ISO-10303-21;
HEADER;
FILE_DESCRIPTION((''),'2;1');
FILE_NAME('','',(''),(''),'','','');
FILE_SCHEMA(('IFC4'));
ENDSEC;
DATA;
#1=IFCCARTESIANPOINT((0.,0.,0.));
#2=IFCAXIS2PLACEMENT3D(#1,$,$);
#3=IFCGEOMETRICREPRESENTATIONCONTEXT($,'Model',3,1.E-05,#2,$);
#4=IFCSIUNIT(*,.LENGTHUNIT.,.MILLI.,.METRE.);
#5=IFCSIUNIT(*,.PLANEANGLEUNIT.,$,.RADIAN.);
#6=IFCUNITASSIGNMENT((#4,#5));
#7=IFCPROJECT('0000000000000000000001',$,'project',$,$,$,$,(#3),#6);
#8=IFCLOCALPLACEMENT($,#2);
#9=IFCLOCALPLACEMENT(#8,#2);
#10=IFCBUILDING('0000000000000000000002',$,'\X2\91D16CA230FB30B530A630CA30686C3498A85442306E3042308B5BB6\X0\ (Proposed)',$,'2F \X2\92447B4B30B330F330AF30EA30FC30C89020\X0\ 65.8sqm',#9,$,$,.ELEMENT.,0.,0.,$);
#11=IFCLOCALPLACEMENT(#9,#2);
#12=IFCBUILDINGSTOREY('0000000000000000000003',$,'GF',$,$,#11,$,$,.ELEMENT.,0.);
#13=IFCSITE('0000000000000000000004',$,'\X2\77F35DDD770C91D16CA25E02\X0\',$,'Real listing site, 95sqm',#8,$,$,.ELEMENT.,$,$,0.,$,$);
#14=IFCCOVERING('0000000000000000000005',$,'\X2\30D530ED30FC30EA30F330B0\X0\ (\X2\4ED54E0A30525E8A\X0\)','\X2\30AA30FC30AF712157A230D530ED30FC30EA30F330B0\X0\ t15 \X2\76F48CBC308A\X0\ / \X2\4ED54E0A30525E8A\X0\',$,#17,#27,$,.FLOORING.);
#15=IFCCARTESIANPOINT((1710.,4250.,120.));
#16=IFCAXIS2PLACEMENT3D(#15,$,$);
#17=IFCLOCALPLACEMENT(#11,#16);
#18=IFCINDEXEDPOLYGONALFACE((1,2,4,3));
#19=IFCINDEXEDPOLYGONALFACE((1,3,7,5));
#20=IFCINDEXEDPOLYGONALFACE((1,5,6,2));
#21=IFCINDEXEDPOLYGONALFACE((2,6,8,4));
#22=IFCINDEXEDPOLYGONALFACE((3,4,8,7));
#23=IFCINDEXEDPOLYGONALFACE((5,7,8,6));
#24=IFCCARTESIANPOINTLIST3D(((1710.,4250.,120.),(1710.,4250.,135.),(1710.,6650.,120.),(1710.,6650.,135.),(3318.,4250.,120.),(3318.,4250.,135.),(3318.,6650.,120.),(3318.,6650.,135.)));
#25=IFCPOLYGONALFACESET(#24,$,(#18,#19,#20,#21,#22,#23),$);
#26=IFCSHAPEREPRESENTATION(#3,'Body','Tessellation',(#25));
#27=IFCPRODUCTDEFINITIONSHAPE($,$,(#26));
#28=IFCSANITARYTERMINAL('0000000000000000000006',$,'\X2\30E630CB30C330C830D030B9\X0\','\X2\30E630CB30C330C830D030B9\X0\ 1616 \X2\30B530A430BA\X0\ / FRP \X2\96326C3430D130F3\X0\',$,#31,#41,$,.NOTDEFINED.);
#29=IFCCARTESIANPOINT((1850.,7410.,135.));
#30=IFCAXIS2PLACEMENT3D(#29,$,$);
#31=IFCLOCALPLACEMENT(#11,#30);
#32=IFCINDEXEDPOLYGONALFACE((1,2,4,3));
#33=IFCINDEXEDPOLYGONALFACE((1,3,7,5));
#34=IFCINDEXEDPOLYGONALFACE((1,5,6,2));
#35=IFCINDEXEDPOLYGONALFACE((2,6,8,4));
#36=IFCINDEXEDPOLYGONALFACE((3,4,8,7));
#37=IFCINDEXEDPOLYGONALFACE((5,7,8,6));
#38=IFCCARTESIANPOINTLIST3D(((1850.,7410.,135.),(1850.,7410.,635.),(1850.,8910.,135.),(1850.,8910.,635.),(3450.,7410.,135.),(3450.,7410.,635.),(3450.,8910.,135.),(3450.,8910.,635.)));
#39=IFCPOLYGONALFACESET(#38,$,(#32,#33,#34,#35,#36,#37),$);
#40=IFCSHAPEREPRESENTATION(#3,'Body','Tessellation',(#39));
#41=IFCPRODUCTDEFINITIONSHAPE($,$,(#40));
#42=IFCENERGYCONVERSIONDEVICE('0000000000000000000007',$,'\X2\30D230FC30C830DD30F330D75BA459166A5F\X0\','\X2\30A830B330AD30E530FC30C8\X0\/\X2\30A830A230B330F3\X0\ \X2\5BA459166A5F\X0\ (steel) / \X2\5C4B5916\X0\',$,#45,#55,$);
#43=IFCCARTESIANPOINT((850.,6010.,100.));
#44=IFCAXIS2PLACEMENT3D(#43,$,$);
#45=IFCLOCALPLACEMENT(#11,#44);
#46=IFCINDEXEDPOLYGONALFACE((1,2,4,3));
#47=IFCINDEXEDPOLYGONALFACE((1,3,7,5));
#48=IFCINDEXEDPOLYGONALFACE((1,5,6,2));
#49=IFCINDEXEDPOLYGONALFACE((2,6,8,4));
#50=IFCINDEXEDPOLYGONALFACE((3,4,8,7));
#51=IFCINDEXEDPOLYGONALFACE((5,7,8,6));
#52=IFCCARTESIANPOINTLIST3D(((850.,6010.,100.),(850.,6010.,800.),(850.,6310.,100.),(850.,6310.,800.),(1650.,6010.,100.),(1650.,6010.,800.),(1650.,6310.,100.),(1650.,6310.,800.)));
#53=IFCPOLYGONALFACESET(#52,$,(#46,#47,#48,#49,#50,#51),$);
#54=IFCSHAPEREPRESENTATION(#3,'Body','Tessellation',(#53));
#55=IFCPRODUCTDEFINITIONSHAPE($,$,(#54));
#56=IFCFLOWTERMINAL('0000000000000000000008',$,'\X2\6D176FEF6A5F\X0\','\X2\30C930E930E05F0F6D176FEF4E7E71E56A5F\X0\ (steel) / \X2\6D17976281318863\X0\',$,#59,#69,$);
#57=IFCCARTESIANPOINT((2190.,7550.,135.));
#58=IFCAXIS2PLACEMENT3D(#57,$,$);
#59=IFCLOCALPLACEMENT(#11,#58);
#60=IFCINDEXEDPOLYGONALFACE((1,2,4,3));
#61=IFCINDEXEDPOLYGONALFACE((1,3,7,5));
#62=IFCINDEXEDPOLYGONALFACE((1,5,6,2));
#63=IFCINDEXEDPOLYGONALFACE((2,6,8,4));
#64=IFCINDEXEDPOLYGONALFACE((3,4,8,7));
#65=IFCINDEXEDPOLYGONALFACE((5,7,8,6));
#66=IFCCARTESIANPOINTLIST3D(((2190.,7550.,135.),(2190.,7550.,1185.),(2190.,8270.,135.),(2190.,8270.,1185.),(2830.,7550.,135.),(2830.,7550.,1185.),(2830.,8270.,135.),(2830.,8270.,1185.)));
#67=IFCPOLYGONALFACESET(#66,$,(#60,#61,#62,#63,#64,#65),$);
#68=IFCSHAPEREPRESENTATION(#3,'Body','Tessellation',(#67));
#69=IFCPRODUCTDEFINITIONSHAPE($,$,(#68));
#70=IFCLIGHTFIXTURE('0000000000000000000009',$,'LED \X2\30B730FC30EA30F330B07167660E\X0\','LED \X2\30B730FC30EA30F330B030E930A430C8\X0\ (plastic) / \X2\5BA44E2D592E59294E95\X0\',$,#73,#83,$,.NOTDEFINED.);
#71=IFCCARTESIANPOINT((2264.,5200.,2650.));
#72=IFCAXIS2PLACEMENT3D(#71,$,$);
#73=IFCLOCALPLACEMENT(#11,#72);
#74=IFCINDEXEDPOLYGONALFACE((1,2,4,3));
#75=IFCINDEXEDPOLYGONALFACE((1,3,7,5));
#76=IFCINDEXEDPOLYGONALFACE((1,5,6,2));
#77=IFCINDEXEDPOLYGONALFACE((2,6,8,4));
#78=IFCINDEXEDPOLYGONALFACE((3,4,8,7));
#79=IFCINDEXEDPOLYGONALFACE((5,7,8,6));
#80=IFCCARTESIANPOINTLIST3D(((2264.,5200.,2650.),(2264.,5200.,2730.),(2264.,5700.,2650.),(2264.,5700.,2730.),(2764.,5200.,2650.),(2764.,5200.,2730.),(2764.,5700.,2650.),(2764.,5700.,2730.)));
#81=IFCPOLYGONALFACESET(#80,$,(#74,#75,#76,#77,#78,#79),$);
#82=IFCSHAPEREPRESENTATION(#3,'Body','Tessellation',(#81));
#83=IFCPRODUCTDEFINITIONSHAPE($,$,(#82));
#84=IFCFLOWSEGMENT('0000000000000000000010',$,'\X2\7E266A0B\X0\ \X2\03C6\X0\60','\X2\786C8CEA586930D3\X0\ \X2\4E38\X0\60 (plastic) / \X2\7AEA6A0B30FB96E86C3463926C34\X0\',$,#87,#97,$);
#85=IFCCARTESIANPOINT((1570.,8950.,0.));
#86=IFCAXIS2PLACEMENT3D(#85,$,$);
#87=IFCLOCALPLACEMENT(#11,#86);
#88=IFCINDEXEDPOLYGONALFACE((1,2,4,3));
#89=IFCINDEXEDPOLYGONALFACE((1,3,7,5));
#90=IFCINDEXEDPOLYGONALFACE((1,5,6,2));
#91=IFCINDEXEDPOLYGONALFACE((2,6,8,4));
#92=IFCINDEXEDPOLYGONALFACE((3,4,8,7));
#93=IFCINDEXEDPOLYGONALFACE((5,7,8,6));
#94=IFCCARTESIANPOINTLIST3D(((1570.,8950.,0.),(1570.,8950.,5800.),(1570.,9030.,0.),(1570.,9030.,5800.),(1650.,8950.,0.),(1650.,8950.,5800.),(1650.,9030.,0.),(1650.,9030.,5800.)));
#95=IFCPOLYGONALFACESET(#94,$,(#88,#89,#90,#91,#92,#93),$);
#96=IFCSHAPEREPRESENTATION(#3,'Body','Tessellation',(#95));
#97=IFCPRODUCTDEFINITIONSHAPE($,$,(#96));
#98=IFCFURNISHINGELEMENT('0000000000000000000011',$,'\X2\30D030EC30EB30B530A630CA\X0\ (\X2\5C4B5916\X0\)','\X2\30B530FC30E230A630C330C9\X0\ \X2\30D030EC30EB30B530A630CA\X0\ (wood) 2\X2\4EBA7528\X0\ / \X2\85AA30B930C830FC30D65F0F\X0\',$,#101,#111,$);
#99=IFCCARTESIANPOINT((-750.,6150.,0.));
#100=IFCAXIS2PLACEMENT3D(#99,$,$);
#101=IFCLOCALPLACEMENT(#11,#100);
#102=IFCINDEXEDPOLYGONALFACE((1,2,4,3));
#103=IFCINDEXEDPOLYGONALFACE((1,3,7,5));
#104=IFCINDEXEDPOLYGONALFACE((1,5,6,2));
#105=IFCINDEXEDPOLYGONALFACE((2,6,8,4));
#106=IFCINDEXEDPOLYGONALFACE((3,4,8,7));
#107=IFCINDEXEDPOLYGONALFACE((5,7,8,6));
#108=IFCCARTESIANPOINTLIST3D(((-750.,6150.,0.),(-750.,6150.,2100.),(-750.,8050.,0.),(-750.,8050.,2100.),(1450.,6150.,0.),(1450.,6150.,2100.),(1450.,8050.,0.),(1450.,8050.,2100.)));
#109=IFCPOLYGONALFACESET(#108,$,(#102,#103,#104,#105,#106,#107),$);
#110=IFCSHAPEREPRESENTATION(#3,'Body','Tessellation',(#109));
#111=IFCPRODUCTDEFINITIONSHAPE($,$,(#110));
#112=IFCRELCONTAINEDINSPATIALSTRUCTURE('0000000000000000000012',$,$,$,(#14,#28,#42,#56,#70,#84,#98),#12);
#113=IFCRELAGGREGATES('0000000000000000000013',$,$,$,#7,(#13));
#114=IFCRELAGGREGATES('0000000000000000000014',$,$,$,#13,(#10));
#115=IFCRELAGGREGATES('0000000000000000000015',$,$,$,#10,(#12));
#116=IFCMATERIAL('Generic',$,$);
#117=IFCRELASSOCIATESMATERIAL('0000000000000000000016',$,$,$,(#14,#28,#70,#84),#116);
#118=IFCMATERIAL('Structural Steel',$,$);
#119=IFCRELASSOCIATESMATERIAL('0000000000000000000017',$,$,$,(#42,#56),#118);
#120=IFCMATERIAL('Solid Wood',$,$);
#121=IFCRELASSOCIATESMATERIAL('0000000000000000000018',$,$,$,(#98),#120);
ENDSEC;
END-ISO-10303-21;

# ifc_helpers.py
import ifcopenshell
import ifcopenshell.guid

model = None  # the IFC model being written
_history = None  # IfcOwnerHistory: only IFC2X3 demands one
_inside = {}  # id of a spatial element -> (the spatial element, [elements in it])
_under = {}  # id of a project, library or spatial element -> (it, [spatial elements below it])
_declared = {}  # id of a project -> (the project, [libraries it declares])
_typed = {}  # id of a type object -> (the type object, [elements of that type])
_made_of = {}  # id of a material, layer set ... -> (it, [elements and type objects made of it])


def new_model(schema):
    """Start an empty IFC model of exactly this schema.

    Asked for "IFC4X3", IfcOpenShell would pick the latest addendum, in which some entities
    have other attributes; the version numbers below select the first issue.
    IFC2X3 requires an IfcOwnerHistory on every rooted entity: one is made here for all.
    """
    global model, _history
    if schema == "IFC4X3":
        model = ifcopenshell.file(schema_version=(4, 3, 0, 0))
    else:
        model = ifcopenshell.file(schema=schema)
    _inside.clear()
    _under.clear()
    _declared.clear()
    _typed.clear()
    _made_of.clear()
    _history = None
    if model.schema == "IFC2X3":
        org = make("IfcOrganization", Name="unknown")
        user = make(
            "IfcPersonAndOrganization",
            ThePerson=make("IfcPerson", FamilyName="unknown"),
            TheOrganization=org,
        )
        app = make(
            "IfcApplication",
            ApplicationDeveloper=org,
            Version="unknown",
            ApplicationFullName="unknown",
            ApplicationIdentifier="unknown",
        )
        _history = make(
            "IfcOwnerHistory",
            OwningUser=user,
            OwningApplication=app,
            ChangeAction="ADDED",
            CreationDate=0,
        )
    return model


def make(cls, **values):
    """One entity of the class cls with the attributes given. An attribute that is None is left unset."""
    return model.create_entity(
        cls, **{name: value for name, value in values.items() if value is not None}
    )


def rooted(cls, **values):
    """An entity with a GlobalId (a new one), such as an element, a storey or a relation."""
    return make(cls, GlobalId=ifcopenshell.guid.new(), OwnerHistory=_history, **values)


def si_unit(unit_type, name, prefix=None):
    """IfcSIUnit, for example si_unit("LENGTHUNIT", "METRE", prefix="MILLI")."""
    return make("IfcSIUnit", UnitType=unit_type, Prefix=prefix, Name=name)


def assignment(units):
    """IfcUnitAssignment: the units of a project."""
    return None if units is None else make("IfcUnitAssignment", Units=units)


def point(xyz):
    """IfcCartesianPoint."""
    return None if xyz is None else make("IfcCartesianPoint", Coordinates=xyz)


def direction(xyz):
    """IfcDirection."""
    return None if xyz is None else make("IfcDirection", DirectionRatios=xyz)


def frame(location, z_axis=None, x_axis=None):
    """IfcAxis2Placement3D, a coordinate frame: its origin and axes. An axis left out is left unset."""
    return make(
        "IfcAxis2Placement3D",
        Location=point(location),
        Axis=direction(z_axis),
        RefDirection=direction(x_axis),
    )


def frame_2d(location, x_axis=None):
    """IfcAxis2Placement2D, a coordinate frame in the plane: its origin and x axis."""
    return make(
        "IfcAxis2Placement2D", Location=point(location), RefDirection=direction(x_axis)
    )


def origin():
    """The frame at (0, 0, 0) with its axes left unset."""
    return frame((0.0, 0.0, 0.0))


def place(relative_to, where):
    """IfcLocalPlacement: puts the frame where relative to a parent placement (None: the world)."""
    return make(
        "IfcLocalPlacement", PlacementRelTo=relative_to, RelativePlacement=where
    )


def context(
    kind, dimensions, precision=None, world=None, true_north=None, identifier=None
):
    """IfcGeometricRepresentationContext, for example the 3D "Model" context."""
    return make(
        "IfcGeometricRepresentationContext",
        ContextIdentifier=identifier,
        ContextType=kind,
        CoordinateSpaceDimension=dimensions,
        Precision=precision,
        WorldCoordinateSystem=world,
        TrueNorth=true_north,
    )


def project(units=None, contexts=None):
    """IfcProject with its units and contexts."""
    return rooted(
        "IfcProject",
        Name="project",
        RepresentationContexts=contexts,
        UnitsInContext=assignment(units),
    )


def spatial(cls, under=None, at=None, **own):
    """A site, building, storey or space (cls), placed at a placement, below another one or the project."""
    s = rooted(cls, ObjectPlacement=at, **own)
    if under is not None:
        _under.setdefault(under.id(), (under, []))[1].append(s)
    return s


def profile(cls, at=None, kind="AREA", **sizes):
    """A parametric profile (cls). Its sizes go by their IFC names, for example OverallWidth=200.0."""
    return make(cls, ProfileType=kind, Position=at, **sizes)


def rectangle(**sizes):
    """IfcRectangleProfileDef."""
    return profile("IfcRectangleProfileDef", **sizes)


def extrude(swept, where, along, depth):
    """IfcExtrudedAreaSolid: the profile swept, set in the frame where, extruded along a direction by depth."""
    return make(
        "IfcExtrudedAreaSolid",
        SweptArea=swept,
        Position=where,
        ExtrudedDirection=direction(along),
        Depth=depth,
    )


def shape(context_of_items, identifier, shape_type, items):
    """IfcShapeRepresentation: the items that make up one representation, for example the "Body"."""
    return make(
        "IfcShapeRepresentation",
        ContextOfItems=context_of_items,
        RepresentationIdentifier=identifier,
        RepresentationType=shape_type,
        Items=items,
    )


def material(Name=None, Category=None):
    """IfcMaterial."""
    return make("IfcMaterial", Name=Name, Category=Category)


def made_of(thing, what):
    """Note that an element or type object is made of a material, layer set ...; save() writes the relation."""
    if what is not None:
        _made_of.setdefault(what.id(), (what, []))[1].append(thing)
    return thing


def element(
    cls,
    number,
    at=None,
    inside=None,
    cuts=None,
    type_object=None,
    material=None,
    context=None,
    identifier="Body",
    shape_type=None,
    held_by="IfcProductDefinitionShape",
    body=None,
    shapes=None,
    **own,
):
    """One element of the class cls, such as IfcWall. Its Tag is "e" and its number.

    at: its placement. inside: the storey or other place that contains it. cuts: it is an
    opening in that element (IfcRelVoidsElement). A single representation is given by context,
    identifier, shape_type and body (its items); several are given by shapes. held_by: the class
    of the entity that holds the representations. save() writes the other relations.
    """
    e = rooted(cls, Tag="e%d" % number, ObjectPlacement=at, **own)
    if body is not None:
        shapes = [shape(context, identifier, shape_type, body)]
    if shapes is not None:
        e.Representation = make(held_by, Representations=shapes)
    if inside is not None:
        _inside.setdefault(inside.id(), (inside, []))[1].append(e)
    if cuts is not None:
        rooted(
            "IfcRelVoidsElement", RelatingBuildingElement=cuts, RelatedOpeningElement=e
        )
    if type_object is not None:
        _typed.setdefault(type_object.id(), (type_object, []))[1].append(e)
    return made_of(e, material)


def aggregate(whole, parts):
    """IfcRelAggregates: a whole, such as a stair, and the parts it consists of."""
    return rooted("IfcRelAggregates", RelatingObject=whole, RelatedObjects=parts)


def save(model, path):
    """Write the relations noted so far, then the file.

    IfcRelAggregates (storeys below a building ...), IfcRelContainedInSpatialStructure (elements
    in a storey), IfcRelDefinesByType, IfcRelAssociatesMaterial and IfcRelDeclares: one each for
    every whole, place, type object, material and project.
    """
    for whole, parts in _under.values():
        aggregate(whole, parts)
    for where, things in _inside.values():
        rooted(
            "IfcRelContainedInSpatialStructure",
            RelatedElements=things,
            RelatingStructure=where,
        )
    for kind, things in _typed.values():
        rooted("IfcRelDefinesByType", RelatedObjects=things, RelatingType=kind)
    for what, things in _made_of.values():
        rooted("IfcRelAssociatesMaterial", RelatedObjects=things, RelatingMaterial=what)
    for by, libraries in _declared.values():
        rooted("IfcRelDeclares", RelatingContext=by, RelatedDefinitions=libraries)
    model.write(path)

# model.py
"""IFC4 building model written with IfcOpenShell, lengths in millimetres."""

from ifc_helpers import new_model, si_unit, frame, frame_2d, origin, place, context, project, spatial, rectangle, extrude, material, element, save


model = new_model("IFC4")

# Units and contexts
model_context = context("Model", 3, precision=1e-05, world=origin())
ifc_project = project(units=[si_unit("LENGTHUNIT", "METRE", prefix="MILLI"), si_unit("PLANEANGLEUNIT", "RADIAN")], contexts=[model_context])

# Site, building, storey
site_placement = place(None, origin())
site = spatial("IfcSite", under=ifc_project, at=site_placement, Name="石川県金沢市", ObjectType="Real listing site, 95sqm", CompositionType="ELEMENT", RefElevation=0.0)
building_placement = place(site_placement, origin())
building = spatial("IfcBuilding", under=site, at=building_placement, Name="金沢・サウナと水風呂のある家 (Proposed)", ObjectType="2F 鉄筋コンクリート造 65.8sqm", CompositionType="ELEMENT", ElevationOfRefHeight=0.0, ElevationOfTerrain=0.0)
storey_placement = place(building_placement, origin())
storey = spatial("IfcBuildingStorey", under=building, at=storey_placement, Name="GF", CompositionType="ELEMENT", Elevation=0.0)

# Shared definitions
ifc_material_1 = material(Name="Solid Wood")

# Covering
ifc_material_2 = material(Name="Generic")
covering_1_placement = place(storey_placement, frame((1710.0, 4250.0, 120.0)))
element("IfcCovering", 1, at=covering_1_placement, inside=storey, material=ifc_material_2, Name="フローリング (仕上げ床)", Description="オーク無垢フローリング t15 直貼り / 仕上げ床", PredefinedType="FLOORING", context=model_context, shape_type="SweptSolid", body=[
    extrude(rectangle(XDim=1608.0, YDim=2400.0, at=frame_2d((804.0, 1200.0))), frame((1710.0, 4250.0, 120.0)), (0.0, 0.0, 1.0), 15.0),
])

# Sanitary terminal
sanitary_terminal_placement = place(storey_placement, frame((1850.0, 7410.0, 135.0)))
element("IfcSanitaryTerminal", 2, at=sanitary_terminal_placement, inside=storey, material=ifc_material_2, Name="ユニットバス", Description="ユニットバス 1616 サイズ / FRP 防水パン", PredefinedType="NOTDEFINED", context=model_context, shape_type="SweptSolid", body=[
    extrude(rectangle(XDim=1600.0, YDim=1500.0, at=frame_2d((800.0, 750.0))), frame((1850.0, 7410.0, 135.0)), (0.0, 0.0, 1.0), 500.0),
])

# Shared definitions
ifc_material_3 = material(Name="Structural Steel")

# Energy conversion device
energy_conversion_device_placement = place(storey_placement, frame((850.0, 6010.0, 100.0)))
element("IfcEnergyConversionDevice", 3, at=energy_conversion_device_placement, inside=storey, material=ifc_material_3, Name="ヒートポンプ室外機", Description="エコキュート/エアコン 室外機 (steel) / 屋外", context=model_context, shape_type="SweptSolid", body=[
    extrude(rectangle(XDim=800.0, YDim=300.0, at=frame_2d((400.0, 150.0))), frame((850.0, 6010.0, 100.0)), (0.0, 0.0, 1.0), 700.0),
])

# Flow terminal
flow_terminal_placement = place(storey_placement, frame((2190.0, 7550.0, 135.0)))
element("IfcFlowTerminal", 4, at=flow_terminal_placement, inside=storey, material=ifc_material_3, Name="洗濯機", Description="ドラム式洗濯乾燥機 (steel) / 洗面脱衣", context=model_context, shape_type="SweptSolid", body=[
    extrude(rectangle(XDim=640.0, YDim=720.0, at=frame_2d((320.0, 360.0))), frame((2190.0, 7550.0, 135.0)), (0.0, 0.0, 1.0), 1050.0),
])

# Light fixture
light_fixture_placement = place(storey_placement, frame((2264.0, 5200.0, 2650.0)))
element("IfcLightFixture", 5, at=light_fixture_placement, inside=storey, material=ifc_material_2, Name="LED シーリング照明", Description="LED シーリングライト (plastic) / 室中央天井", PredefinedType="NOTDEFINED", context=model_context, shape_type="SweptSolid", body=[
    extrude(rectangle(XDim=500.0, YDim=500.0, at=frame_2d((250.0, 250.0))), frame((2264.0, 5200.0, 2650.0)), (0.0, 0.0, 1.0), 80.0),
])

# Flow segment
flow_segment_placement = place(storey_placement, frame((1570.0, 8950.0, 0.0)))
element("IfcFlowSegment", 6, at=flow_segment_placement, inside=storey, material=ifc_material_2, Name="縦樋 φ60", Description="硬質塩ビ 丸60 (plastic) / 竪樋・雨水排水", context=model_context, shape_type="SweptSolid", body=[
    extrude(rectangle(XDim=80.0, YDim=80.0, at=frame_2d((40.0, 40.0))), frame((1570.0, 8950.0, 0.0)), (0.0, 0.0, 1.0), 5800.0),
])

# Furnishing element
furnishing_placement = place(storey_placement, frame((-750.0, 6150.0, 0.0)))
element("IfcFurnishingElement", 7, at=furnishing_placement, inside=storey, material=ifc_material_1, Name="バレルサウナ (屋外)", Description="サーモウッド バレルサウナ (wood) 2人用 / 薪ストーブ式", context=model_context, shape_type="SweptSolid", body=[
    extrude(rectangle(XDim=2200.0, YDim=1900.0, at=frame_2d((1100.0, 950.0))), frame((-750.0, 6150.0, 0.0)), (0.0, 0.0, 1.0), 2100.0),
])

save(model, "model.ifc")
